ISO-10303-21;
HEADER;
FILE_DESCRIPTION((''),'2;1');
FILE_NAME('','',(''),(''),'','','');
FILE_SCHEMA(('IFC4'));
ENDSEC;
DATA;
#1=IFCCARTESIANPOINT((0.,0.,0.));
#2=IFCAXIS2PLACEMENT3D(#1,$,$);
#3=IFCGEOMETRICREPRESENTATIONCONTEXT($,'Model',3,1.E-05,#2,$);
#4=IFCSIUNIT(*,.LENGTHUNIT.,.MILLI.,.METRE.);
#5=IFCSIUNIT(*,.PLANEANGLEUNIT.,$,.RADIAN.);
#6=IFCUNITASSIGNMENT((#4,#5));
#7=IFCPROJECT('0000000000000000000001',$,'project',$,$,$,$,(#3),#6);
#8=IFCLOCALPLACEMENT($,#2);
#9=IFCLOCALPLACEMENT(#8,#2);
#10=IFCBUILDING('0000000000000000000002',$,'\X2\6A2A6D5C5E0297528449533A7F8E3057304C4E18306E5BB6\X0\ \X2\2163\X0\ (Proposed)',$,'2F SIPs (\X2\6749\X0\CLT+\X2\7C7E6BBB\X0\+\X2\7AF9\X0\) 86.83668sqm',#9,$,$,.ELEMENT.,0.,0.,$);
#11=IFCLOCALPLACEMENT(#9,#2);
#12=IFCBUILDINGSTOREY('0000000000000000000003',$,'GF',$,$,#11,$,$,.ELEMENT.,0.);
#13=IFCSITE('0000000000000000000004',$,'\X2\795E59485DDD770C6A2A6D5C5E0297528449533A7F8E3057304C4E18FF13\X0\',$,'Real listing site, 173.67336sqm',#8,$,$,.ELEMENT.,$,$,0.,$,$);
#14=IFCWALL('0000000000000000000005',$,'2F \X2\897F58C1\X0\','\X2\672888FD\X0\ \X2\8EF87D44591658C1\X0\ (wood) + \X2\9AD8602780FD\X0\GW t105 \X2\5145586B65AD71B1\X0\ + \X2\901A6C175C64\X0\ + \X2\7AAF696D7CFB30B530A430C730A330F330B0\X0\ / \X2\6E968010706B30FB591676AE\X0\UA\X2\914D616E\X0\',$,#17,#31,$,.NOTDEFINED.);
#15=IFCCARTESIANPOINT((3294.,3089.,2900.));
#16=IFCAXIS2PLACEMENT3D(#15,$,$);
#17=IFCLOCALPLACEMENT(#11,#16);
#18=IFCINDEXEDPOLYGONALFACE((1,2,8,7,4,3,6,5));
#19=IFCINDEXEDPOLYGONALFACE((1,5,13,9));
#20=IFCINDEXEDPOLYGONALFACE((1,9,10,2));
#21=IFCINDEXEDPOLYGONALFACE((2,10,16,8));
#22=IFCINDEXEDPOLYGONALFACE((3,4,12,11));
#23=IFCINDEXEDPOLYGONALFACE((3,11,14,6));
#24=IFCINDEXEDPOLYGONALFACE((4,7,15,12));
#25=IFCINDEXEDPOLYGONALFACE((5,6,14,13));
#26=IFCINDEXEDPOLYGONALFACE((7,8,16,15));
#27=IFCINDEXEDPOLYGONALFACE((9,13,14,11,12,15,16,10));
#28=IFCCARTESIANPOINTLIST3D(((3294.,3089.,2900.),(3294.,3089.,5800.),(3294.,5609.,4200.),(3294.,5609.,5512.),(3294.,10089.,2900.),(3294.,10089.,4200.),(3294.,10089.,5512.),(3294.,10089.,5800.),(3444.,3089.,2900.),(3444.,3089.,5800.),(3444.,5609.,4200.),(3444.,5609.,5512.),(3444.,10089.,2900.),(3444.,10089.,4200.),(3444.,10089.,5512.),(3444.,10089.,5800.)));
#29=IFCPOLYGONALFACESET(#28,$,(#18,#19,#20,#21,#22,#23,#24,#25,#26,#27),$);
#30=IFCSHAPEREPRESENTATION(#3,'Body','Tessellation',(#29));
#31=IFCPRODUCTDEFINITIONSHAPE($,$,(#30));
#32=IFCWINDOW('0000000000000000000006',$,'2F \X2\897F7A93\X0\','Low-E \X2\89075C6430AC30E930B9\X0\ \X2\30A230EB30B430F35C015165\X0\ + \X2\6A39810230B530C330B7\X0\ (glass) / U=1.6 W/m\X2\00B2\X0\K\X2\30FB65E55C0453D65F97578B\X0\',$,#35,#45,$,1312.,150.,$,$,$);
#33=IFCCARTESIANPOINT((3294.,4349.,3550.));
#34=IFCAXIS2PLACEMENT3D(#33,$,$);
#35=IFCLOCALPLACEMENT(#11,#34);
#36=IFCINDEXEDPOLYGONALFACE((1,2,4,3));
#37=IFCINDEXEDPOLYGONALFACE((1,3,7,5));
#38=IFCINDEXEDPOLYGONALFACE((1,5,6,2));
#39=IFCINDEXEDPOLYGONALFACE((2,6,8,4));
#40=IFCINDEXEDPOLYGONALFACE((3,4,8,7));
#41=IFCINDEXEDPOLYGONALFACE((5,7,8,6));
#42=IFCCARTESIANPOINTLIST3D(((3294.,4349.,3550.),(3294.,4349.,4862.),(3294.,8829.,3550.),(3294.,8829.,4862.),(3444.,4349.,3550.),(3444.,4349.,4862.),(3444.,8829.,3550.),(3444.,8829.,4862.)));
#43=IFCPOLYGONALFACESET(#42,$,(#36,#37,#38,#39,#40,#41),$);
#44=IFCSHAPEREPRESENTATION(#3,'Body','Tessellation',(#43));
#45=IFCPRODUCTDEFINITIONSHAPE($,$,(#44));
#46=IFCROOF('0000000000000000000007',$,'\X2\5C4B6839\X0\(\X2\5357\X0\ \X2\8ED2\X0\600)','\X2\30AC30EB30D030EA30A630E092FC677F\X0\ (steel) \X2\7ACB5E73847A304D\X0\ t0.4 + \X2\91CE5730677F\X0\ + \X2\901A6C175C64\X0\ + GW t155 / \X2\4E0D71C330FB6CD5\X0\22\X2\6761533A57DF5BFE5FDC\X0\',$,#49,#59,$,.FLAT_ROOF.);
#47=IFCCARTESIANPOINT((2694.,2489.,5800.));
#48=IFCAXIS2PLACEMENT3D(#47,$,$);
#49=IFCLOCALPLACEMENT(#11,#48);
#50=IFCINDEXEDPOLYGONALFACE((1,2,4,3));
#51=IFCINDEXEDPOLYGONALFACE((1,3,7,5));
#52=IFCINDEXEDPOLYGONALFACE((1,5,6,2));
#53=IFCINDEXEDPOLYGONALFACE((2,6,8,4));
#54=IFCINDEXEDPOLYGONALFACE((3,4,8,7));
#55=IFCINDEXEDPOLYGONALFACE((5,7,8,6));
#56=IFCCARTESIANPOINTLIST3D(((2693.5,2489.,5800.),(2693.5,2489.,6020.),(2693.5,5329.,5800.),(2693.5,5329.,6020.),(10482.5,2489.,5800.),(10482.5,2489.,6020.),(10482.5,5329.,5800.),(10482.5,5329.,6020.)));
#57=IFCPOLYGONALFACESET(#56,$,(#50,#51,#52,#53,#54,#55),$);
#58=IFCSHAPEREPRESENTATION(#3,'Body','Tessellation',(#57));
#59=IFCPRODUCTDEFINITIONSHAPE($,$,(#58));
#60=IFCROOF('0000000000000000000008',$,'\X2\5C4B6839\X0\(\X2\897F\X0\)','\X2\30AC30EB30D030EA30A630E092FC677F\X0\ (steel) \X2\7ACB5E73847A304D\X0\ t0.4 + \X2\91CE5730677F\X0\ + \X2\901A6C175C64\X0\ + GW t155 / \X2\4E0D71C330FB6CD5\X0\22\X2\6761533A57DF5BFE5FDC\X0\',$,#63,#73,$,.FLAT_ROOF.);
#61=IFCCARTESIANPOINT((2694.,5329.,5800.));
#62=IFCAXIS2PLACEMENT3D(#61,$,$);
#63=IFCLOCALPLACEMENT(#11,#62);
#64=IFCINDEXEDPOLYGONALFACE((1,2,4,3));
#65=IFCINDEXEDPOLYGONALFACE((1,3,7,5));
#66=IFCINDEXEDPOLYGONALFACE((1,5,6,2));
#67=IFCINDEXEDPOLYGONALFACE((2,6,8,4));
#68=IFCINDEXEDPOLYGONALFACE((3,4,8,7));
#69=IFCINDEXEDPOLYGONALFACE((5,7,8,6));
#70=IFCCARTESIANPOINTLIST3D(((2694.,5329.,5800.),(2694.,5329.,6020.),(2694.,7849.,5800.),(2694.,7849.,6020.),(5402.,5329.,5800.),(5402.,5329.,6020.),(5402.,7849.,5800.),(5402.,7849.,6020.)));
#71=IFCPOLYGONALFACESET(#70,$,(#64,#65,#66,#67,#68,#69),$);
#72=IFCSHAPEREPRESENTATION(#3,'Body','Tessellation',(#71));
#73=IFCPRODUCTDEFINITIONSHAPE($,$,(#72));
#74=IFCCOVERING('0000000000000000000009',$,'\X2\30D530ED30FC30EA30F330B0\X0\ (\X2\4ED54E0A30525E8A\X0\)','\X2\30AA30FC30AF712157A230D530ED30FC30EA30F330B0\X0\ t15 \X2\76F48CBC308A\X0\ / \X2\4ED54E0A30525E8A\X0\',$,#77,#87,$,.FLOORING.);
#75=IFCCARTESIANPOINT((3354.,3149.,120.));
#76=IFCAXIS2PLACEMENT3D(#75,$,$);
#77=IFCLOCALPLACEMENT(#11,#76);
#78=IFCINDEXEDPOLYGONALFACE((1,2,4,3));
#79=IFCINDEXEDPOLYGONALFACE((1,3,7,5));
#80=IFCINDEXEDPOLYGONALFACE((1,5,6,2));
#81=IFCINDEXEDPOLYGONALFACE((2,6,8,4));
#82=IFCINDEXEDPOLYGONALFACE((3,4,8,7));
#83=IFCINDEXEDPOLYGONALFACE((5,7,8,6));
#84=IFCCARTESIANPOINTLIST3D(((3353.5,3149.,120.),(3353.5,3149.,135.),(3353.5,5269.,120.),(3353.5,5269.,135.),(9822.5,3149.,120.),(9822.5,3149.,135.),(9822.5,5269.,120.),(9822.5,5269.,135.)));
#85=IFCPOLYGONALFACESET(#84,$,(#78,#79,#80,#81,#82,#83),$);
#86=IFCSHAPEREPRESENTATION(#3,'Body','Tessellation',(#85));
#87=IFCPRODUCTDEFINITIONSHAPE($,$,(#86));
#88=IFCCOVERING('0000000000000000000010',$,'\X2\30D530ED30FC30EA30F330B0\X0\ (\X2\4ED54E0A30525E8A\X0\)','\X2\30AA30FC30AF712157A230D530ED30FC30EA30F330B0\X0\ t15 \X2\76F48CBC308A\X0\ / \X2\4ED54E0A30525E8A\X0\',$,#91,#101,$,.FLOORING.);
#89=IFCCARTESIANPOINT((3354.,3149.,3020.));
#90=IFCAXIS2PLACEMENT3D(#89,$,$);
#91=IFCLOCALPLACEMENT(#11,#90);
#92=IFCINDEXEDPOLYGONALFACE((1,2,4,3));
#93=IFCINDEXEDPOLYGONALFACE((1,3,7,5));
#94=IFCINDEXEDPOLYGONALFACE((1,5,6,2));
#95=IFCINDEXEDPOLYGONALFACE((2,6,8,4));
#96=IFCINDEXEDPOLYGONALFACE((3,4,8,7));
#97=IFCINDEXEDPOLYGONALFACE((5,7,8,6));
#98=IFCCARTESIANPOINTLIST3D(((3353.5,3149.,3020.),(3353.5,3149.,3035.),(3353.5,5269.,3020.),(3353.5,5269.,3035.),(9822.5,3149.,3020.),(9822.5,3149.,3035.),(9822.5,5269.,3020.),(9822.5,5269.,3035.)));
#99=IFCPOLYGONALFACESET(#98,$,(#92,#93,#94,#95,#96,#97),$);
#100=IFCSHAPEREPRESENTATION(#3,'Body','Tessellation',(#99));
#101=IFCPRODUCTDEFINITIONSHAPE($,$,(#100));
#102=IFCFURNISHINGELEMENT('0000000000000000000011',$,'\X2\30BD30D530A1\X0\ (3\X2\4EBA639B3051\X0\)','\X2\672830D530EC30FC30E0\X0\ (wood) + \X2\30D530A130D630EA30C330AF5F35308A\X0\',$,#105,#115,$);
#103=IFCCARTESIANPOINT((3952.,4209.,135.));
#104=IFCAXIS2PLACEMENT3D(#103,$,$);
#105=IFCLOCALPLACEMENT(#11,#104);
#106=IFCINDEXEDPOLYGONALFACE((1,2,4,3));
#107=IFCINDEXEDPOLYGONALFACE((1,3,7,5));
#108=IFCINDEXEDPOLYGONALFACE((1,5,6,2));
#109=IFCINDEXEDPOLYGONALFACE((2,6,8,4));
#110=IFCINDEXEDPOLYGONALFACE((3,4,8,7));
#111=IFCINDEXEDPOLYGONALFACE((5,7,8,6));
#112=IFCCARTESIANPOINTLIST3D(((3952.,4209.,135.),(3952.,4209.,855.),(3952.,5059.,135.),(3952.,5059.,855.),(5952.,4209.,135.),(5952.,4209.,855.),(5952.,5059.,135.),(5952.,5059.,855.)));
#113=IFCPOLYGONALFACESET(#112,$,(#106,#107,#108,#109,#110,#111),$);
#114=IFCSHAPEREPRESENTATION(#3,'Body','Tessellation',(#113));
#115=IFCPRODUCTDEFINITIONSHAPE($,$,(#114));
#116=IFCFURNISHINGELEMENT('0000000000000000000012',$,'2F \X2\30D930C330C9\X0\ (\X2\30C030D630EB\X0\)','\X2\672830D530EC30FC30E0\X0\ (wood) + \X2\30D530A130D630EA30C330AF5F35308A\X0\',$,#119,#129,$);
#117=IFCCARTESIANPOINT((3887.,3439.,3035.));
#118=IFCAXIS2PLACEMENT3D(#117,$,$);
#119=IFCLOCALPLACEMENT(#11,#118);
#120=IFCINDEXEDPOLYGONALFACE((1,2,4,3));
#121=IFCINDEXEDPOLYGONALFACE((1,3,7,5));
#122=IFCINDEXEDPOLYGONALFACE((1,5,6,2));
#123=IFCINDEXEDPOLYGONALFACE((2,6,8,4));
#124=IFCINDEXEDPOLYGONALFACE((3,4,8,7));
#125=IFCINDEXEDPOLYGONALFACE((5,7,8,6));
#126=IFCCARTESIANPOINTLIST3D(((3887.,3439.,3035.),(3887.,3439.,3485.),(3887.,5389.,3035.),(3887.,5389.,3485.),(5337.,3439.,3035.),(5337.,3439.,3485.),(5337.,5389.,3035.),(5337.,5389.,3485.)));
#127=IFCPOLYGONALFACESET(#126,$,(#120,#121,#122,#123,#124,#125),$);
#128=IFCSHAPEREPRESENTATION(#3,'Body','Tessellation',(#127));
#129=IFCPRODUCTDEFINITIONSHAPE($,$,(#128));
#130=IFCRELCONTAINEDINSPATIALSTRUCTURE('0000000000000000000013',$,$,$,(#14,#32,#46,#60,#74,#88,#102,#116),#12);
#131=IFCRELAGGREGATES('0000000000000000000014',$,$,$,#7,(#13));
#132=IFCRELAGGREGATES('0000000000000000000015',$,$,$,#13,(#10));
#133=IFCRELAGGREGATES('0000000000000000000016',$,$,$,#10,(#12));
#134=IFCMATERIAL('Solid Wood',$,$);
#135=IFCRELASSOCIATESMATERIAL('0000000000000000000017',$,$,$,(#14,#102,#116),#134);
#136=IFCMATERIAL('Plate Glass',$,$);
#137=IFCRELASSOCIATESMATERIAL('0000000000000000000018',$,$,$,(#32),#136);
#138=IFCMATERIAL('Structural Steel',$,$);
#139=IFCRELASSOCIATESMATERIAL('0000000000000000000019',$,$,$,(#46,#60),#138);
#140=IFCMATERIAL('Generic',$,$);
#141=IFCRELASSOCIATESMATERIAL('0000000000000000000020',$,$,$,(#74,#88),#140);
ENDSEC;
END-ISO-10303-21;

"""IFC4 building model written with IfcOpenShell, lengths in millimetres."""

from ifc_helpers import new_model, si_unit, frame, frame_2d, origin, place, context, project, spatial, rectangle, extrude, material, element, fill, save


model = new_model("IFC4")

# Units and contexts
model_context = context("Model", 3, precision=1e-05, world=origin())
ifc_project = project(units=[si_unit("LENGTHUNIT", "METRE", prefix="MILLI"), si_unit("PLANEANGLEUNIT", "RADIAN")], contexts=[model_context])

# Site, building, storey
site_placement = place(None, origin())
site = spatial("IfcSite", under=ifc_project, at=site_placement, Name="神奈川県横浜市青葉区美しが丘３", ObjectType="Real listing site, 173.67336sqm", CompositionType="ELEMENT", RefElevation=0.0)
building_placement = place(site_placement, origin())
building = spatial("IfcBuilding", under=site, at=building_placement, Name="横浜市青葉区美しが丘の家 Ⅳ (Proposed)", ObjectType="2F SIPs (杉CLT+籾殻+竹) 86.83668sqm", CompositionType="ELEMENT", ElevationOfRefHeight=0.0, ElevationOfTerrain=0.0)
storey_placement = place(building_placement, origin())
storey = spatial("IfcBuildingStorey", under=building, at=storey_placement, Name="GF", CompositionType="ELEMENT", Elevation=0.0)

# Shared definitions
ifc_material_1 = material(Name="Solid Wood")

# Shared definitions
ifc_material_2 = material(Name="Plate Glass")

# Wall, opening, window
wall_1_placement = place(storey_placement, frame((3294.0, 3089.0, 2900.0)))
wall_1 = element("IfcWall", 1, at=wall_1_placement, inside=storey, material=ifc_material_1, Name="2F 西壁", Description="木製 軸組外壁 (wood) + 高性能GW t105 充填断熱 + 通気層 + 窯業系サイディング / 準耐火・外皮UA配慮", PredefinedType="NOTDEFINED", context=model_context, shape_type="SweptSolid", body=[
    extrude(rectangle(XDim=150.0, YDim=7000.0, at=frame_2d((75.0, 3500.0))), frame((3294.0, 3089.0, 2900.0)), (0.0, 0.0, 1.0), 2900.0),
])
opening_1_placement = place(storey_placement, frame((3294.0, 4349.0, 3550.0)))
opening_1 = element("IfcOpeningElement", 2, at=opening_1_placement, cuts=wall_1, PredefinedType="NOTDEFINED", context=model_context, shape_type="SweptSolid", body=[
    extrude(rectangle(XDim=150.0, YDim=4480.0, at=frame_2d((75.0, 2240.0))), frame((3294.0, 4349.0, 3550.0)), (0.0, 0.0, 1.0), 1312.0),
])
window_1_placement = place(storey_placement, frame((3294.0, 4349.0, 3550.0)))
window_1 = element("IfcWindow", 3, at=window_1_placement, inside=storey, material=ifc_material_2, Name="2F 西窓", Description="Low-E 複層ガラス アルゴン封入 + 樹脂サッシ (glass) / U=1.6 W/m²K・日射取得型", OverallHeight=1312.0, OverallWidth=150.0, context=model_context, shape_type="SweptSolid", body=[
    extrude(rectangle(XDim=150.0, YDim=4480.0, at=frame_2d((75.0, 2240.0))), frame((3294.0, 4349.0, 3550.0)), (0.0, 0.0, 1.0), 1312.0),
])
fill(opening_1, window_1)

# Roofs
ifc_material_3 = material(Name="Structural Steel")
roof_1_placement = place(storey_placement, frame((2694.0, 2489.0, 5800.0)))
element("IfcRoof", 4, at=roof_1_placement, inside=storey, material=ifc_material_3, Name="屋根(南 軒600)", Description="ガルバリウム鋼板 (steel) 立平葺き t0.4 + 野地板 + 通気層 + GW t155 / 不燃・法22条区域対応", PredefinedType="FLAT_ROOF", context=model_context, shape_type="SweptSolid", body=[
    extrude(rectangle(XDim=7789.0, YDim=2840.0, at=frame_2d((3894.0, 1420.0))), frame((2694.0, 2489.0, 5800.0)), (0.0, 0.0, 1.0), 220.0),
])
roof_2_placement = place(storey_placement, frame((2694.0, 5329.0, 5800.0)))
element("IfcRoof", 5, at=roof_2_placement, inside=storey, material=ifc_material_3, Name="屋根(西)", Description="ガルバリウム鋼板 (steel) 立平葺き t0.4 + 野地板 + 通気層 + GW t155 / 不燃・法22条区域対応", PredefinedType="FLAT_ROOF", context=model_context, shape_type="SweptSolid", body=[
    extrude(rectangle(XDim=2708.0, YDim=2520.0, at=frame_2d((1354.0, 1260.0))), frame((2694.0, 5329.0, 5800.0)), (0.0, 0.0, 1.0), 220.0),
])

# Coverings
ifc_material_4 = material(Name="Generic")
covering_1_placement = place(storey_placement, frame((3354.0, 3149.0, 120.0)))
element("IfcCovering", 6, at=covering_1_placement, inside=storey, material=ifc_material_4, Name="フローリング (仕上げ床)", Description="オーク無垢フローリング t15 直貼り / 仕上げ床", PredefinedType="FLOORING", context=model_context, shape_type="SweptSolid", body=[
    extrude(rectangle(XDim=6469.0, YDim=2120.0, at=frame_2d((3234.0, 1060.0))), frame((3354.0, 3149.0, 120.0)), (0.0, 0.0, 1.0), 15.0),
])
covering_2_placement = place(storey_placement, frame((3354.0, 3149.0, 3020.0)))
element("IfcCovering", 7, at=covering_2_placement, inside=storey, material=ifc_material_4, Name="フローリング (仕上げ床)", Description="オーク無垢フローリング t15 直貼り / 仕上げ床", PredefinedType="FLOORING", context=model_context, shape_type="SweptSolid", body=[
    extrude(rectangle(XDim=6469.0, YDim=2120.0, at=frame_2d((3234.0, 1060.0))), frame((3354.0, 3149.0, 3020.0)), (0.0, 0.0, 1.0), 15.0),
])

# Furnishing elements
furnishing_1_placement = place(storey_placement, frame((3952.0, 4209.0, 135.0)))
element("IfcFurnishingElement", 8, at=furnishing_1_placement, inside=storey, material=ifc_material_1, Name="ソファ (3人掛け)", Description="木フレーム (wood) + ファブリック張り", context=model_context, shape_type="SweptSolid", body=[
    extrude(rectangle(XDim=2000.0, YDim=850.0, at=frame_2d((1000.0, 425.0))), frame((3952.0, 4209.0, 135.0)), (0.0, 0.0, 1.0), 720.0),
])
furnishing_2_placement = place(storey_placement, frame((3887.0, 3439.0, 3035.0)))
element("IfcFurnishingElement", 9, at=furnishing_2_placement, inside=storey, material=ifc_material_1, Name="2F ベッド (ダブル)", Description="木フレーム (wood) + ファブリック張り", context=model_context, shape_type="SweptSolid", body=[
    extrude(rectangle(XDim=1450.0, YDim=1950.0, at=frame_2d((725.0, 975.0))), frame((3887.0, 3439.0, 3035.0)), (0.0, 0.0, 1.0), 450.0),
])

save(model, "model.ifc")
